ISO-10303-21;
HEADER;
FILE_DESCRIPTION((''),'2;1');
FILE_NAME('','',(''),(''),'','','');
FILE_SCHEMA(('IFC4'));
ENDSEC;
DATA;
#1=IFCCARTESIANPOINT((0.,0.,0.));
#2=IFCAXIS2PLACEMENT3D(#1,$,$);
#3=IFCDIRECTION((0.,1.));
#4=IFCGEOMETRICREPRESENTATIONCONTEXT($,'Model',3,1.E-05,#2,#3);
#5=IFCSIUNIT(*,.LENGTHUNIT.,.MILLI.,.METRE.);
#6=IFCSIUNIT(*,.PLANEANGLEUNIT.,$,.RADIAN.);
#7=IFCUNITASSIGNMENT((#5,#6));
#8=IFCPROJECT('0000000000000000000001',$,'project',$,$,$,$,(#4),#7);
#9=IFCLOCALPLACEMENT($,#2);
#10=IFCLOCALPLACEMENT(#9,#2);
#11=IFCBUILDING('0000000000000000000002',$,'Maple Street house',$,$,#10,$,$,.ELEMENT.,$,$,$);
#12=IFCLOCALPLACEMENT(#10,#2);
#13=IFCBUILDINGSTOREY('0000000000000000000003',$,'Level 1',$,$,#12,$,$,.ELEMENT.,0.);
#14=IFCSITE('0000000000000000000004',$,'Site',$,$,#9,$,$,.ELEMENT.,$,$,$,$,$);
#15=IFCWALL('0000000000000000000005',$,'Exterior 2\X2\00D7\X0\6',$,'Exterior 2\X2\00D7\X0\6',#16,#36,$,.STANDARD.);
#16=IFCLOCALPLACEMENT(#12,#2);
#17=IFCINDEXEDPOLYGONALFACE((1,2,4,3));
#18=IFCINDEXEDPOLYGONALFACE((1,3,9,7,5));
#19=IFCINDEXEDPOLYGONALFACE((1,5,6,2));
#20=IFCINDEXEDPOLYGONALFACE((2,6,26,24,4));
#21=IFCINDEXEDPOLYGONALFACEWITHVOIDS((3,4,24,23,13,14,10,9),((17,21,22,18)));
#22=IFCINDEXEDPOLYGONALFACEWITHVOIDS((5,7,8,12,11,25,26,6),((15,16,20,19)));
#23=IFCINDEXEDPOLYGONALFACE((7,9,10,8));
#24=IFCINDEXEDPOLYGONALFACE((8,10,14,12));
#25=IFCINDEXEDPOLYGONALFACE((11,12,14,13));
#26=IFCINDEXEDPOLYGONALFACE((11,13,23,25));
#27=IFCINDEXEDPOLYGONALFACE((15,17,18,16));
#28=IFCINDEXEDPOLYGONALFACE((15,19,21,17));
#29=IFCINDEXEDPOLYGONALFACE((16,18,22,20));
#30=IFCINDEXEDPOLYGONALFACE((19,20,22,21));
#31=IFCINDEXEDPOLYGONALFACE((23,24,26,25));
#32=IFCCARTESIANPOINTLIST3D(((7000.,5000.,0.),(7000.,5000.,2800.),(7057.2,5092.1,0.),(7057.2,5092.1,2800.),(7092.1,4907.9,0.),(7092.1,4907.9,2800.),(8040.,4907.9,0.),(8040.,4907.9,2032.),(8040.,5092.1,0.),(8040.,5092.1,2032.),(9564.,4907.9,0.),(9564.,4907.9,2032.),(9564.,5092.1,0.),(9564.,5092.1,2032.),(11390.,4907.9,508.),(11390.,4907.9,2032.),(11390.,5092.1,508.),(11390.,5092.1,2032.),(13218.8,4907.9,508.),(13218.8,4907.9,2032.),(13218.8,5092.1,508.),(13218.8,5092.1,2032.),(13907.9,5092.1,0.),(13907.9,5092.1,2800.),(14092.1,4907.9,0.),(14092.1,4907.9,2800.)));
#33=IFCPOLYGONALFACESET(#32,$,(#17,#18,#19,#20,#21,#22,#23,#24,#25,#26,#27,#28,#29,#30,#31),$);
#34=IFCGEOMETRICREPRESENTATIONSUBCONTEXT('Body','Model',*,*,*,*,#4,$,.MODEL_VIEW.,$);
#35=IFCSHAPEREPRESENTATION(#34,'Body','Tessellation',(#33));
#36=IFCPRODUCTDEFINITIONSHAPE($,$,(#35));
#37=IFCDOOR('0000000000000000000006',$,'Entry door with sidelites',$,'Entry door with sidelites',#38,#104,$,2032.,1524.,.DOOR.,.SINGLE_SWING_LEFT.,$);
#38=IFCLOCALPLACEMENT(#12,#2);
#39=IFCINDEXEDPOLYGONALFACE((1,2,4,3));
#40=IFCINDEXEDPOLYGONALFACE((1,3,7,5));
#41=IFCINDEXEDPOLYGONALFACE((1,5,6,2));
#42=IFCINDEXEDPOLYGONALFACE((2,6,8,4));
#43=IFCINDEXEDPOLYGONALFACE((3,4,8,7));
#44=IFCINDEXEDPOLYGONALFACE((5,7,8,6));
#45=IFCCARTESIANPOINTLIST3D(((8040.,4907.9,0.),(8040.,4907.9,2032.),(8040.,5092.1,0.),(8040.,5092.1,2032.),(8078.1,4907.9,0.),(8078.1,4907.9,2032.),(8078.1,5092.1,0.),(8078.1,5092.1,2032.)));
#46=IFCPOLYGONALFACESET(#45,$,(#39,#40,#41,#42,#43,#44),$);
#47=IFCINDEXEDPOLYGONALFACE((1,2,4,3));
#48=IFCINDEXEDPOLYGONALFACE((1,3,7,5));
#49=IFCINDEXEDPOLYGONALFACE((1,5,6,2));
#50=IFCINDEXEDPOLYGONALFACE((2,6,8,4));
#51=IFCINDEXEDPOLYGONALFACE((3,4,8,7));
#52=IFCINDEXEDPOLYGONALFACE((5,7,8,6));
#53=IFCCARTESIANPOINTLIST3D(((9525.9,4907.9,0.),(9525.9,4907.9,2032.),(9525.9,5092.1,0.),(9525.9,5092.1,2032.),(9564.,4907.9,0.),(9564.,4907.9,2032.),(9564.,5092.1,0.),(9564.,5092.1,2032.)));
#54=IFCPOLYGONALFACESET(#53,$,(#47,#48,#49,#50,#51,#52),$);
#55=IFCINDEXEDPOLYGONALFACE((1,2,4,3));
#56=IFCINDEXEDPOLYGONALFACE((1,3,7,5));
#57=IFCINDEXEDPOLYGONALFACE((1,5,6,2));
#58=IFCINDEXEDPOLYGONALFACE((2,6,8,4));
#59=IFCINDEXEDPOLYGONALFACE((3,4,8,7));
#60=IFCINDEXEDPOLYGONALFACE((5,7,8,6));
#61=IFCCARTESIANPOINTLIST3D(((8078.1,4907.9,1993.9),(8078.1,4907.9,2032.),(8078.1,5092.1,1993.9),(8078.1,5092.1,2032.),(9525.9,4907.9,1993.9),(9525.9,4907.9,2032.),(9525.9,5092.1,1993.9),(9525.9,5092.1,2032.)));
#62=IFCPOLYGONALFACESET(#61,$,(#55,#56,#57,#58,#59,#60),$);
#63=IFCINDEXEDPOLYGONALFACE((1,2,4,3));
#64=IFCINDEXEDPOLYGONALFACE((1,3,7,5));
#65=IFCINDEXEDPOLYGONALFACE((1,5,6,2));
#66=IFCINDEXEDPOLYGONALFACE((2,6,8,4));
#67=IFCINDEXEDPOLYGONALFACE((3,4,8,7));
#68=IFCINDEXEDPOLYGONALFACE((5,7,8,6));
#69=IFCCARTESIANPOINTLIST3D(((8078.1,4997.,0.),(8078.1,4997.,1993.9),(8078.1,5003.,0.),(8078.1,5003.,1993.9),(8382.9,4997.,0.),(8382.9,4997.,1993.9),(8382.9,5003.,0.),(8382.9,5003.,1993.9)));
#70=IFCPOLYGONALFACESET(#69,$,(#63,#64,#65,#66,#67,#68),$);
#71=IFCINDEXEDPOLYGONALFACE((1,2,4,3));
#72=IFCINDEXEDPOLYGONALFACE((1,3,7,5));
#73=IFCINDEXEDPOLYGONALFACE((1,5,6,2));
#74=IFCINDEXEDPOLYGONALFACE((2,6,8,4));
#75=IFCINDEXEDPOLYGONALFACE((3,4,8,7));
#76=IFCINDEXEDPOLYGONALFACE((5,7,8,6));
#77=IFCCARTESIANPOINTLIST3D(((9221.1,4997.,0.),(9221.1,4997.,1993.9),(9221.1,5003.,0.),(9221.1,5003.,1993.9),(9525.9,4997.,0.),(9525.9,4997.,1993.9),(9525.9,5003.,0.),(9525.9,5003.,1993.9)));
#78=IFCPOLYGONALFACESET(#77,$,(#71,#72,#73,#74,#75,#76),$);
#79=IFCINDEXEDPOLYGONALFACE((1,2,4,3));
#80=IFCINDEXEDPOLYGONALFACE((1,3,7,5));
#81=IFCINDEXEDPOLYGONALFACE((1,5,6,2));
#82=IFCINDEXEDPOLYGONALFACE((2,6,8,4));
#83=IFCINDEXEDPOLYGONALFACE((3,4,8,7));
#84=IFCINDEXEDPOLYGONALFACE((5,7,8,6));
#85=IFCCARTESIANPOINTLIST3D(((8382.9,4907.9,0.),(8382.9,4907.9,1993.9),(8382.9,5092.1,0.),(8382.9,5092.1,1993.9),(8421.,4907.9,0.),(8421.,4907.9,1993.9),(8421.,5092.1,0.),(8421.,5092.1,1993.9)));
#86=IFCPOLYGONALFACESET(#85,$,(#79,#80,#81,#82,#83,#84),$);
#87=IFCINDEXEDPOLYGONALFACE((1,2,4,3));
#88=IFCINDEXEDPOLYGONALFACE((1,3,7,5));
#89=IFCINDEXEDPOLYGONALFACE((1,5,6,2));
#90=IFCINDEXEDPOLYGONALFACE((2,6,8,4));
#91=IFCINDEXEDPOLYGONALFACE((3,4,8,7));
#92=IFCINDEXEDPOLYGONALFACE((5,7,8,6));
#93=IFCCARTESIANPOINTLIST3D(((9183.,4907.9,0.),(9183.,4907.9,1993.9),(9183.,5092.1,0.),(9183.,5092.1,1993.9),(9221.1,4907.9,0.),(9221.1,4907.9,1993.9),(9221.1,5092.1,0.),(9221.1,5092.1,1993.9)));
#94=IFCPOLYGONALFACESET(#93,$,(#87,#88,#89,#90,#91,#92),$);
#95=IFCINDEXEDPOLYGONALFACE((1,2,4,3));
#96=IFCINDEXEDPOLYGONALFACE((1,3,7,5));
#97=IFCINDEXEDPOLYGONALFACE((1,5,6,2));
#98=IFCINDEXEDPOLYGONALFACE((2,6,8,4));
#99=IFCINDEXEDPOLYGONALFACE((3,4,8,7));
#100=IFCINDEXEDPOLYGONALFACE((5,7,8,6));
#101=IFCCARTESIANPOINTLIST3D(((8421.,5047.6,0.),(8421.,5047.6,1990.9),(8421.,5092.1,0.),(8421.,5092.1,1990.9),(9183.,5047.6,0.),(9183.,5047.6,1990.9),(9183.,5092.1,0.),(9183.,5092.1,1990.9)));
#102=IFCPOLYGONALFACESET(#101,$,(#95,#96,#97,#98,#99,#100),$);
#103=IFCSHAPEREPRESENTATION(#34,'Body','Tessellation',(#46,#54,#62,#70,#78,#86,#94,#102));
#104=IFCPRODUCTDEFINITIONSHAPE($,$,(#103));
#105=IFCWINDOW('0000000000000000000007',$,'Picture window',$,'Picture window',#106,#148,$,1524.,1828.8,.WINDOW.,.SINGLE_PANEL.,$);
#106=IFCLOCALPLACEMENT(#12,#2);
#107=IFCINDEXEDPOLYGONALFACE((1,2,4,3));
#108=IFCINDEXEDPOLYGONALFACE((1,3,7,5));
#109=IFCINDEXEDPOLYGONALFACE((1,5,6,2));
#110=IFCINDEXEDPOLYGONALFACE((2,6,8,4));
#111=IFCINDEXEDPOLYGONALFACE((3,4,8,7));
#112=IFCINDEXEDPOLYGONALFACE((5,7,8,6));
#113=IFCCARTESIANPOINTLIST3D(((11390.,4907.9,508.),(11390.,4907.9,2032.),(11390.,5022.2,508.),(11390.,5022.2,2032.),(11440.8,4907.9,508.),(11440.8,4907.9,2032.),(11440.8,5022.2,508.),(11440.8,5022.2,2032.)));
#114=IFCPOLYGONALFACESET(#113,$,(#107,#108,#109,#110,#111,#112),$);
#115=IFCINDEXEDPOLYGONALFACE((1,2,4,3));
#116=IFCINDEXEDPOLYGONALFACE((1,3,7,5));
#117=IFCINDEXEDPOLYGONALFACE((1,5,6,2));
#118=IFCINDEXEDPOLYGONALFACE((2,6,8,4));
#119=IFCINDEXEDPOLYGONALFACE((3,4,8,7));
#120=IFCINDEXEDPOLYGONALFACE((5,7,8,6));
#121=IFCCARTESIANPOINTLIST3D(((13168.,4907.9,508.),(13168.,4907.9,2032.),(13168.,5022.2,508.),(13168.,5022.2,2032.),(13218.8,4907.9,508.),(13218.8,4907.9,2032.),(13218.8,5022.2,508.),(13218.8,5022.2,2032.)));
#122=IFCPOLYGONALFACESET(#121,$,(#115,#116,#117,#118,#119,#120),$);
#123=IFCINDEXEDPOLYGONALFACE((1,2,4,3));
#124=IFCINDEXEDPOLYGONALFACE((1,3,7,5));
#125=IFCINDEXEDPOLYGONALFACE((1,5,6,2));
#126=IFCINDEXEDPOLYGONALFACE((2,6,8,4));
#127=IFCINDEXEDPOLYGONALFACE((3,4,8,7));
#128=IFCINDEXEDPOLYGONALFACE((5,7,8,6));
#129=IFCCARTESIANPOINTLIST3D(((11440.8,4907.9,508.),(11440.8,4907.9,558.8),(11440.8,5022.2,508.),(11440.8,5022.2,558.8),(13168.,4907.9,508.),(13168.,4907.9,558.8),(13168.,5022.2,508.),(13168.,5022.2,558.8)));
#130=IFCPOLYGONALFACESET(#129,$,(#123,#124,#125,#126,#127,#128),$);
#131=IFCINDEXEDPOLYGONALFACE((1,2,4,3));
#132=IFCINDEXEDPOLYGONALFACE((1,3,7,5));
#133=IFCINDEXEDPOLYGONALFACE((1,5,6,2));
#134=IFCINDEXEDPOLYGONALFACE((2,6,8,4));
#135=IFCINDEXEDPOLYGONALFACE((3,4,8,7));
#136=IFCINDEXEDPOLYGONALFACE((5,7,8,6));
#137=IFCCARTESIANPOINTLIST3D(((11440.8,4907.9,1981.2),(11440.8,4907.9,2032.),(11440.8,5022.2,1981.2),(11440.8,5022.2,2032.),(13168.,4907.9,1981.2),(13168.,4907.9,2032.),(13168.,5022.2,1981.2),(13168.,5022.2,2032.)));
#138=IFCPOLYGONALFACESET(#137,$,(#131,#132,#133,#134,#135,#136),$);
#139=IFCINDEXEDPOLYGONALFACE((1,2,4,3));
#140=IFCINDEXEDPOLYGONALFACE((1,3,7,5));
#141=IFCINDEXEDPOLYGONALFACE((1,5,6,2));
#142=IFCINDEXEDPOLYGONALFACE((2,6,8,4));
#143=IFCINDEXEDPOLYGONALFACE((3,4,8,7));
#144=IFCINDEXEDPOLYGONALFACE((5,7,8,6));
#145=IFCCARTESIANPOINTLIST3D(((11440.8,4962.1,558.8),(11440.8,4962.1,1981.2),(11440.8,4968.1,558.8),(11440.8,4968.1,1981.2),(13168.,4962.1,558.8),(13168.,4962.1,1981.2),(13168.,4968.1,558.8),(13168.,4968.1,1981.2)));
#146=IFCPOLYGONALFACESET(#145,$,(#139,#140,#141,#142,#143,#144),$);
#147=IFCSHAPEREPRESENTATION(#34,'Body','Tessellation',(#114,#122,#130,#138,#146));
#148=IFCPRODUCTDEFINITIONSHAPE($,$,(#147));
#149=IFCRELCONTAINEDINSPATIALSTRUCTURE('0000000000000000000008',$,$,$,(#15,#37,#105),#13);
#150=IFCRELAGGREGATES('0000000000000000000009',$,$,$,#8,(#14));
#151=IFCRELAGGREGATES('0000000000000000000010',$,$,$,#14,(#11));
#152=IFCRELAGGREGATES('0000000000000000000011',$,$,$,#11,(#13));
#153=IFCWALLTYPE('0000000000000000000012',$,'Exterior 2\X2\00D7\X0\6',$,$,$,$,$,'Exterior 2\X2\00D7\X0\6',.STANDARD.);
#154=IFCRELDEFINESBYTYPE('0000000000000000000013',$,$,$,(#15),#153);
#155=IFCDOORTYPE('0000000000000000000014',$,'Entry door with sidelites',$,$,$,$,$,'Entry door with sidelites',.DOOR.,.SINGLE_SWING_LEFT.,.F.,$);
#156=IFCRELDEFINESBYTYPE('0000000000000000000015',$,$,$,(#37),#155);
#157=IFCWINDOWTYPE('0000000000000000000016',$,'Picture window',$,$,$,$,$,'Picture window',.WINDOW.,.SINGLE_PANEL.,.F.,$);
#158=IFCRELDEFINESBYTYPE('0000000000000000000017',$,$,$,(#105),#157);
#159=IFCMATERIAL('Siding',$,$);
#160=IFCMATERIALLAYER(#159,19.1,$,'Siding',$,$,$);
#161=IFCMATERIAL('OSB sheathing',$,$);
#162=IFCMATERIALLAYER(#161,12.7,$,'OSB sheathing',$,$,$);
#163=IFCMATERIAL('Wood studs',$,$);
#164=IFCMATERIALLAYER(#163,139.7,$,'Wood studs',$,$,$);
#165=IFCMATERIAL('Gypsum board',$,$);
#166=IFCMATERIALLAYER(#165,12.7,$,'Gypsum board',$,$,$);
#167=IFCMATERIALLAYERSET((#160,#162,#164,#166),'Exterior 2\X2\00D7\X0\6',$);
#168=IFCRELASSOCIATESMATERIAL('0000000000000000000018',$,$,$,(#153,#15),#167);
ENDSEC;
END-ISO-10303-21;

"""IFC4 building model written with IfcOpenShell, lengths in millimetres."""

from ifc_helpers import new_model, si_unit, direction, frame, origin, origin_with_axes, place, context, subcontext, project, spatial, polyline, outline, extrude, material, layer, layer_set, layer_usage, type_object, element, fill, save


model = new_model("IFC4")

# Units and contexts
model_context = context("Model", 3, precision=1e-05, world=origin(), true_north=direction((0.0, 1.0)))
body_context = subcontext(model_context, "Body", "Model", "MODEL_VIEW")
ifc_project = project(units=[si_unit("LENGTHUNIT", "METRE", prefix="MILLI"), si_unit("PLANEANGLEUNIT", "RADIAN")], contexts=[model_context])

# Site, building, storey
site_placement = place(None, origin())
site = spatial("IfcSite", under=ifc_project, at=site_placement, Name="Site", CompositionType="ELEMENT")
building_placement = place(site_placement, origin())
building = spatial("IfcBuilding", under=site, at=building_placement, Name="Maple Street house", CompositionType="ELEMENT")
storey_placement = place(building_placement, origin())
storey = spatial("IfcBuildingStorey", under=building, at=storey_placement, Name="Level 1", CompositionType="ELEMENT", Elevation=0.0)

# Wall, openings, door, window
ifc_material_1 = material(Name="Siding")
ifc_layer_1 = layer(ifc_material_1, 19.1, Name="Siding")
ifc_material_2 = material(Name="OSB sheathing")
ifc_layer_2 = layer(ifc_material_2, 12.7, Name="OSB sheathing")
ifc_material_3 = material(Name="Wood studs")
ifc_layer_3 = layer(ifc_material_3, 139.7, Name="Wood studs")
ifc_material_4 = material(Name="Gypsum board")
ifc_layer_4 = layer(ifc_material_4, 12.7, Name="Gypsum board")
ifc_layer_set_1 = layer_set([ifc_layer_1, ifc_layer_2, ifc_layer_3, ifc_layer_4], Name="Exterior 2×6")
ifc_layer_usage_1 = layer_usage(ifc_layer_set_1, "AXIS2", "POSITIVE", -92.1)
wall_type_1 = type_object("IfcWallType", Name="Exterior 2×6", ElementType="Exterior 2×6", PredefinedType="STANDARD", material=ifc_layer_set_1)
wall_1_placement = place(storey_placement, frame((7000.0, 5000.0, 0.0), z_axis=(0.0, 0.0, 1.0), x_axis=(1.0, 0.0, 0.0)))
wall_1 = element("IfcWall", 1, at=wall_1_placement, inside=storey, type_object=wall_type_1, material=ifc_layer_usage_1, Name="Exterior 2×6", ObjectType="Exterior 2×6", PredefinedType="STANDARD", context=body_context, shape_type="SweptSolid", body=[
    extrude(outline(polyline([(92.1, -92.1), (7092.1, -92.1), (6907.9, 92.1), (57.1, 92.1), (0.0, 0.0), (92.1, -92.1)])), origin(), (0.0, 0.0, 1.0), 2800.0),
])
opening_1_placement = place(wall_1_placement, frame((1040.0, 0.0, 0.0), z_axis=(0.0, 0.0, 1.0), x_axis=(1.0, 0.0, 0.0)))
opening_1 = element("IfcOpeningElement", 2, at=opening_1_placement, cuts=wall_1, PredefinedType="OPENING", context=body_context, shape_type="SweptSolid", body=[
    extrude(outline(polyline([(0.0, -102.1), (1524.0, -102.1), (1524.0, 102.1), (0.0, 102.1), (0.0, -102.1)])), origin(), (0.0, 0.0, 1.0), 2032.0),
])
opening_2_placement = place(wall_1_placement, frame((4390.0, 0.0, 508.0), z_axis=(0.0, 0.0, 1.0), x_axis=(1.0, 0.0, 0.0)))
opening_2 = element("IfcOpeningElement", 3, at=opening_2_placement, cuts=wall_1, PredefinedType="OPENING", context=body_context, shape_type="SweptSolid", body=[
    extrude(outline(polyline([(0.0, -102.1), (1828.8, -102.1), (1828.8, 102.1), (0.0, 102.1), (0.0, -102.1)])), origin(), (0.0, 0.0, 1.0), 1524.0),
])
door_type_1 = type_object("IfcDoorType", Name="Entry door with sidelites", ElementType="Entry door with sidelites", OperationType="SINGLE_SWING_LEFT", ParameterTakesPrecedence=False, PredefinedType="DOOR")
door_1_placement = place(opening_1_placement, origin_with_axes())
door_1 = element("IfcDoor", 4, at=door_1_placement, inside=storey, type_object=door_type_1, Name="Entry door with sidelites", ObjectType="Entry door with sidelites", OperationType="SINGLE_SWING_LEFT", OverallHeight=2032.0, OverallWidth=1524.0, PredefinedType="DOOR", context=body_context, shape_type="SweptSolid", body=[
    extrude(outline(polyline([(0.0, -92.1), (38.1, -92.1), (38.1, 92.1), (0.0, 92.1), (0.0, -92.1)])), origin(), (0.0, 0.0, 1.0), 2032.0),
    extrude(outline(polyline([(1485.9, -92.1), (1524.0, -92.1), (1524.0, 92.1), (1485.9, 92.1), (1485.9, -92.1)])), origin(), (0.0, 0.0, 1.0), 2032.0),
    extrude(outline(polyline([(38.1, -92.1), (1485.9, -92.1), (1485.9, 92.1), (38.1, 92.1), (38.1, -92.1)])), frame((0.0, 0.0, 1993.9)), (0.0, 0.0, 1.0), 38.1),
    extrude(outline(polyline([(38.1, -3.0), (342.9, -3.0), (342.9, 3.0), (38.1, 3.0), (38.1, -3.0)])), origin(), (0.0, 0.0, 1.0), 1993.9),
    extrude(outline(polyline([(1181.1, -3.0), (1485.9, -3.0), (1485.9, 3.0), (1181.1, 3.0), (1181.1, -3.0)])), origin(), (0.0, 0.0, 1.0), 1993.9),
    extrude(outline(polyline([(342.9, -92.1), (381.0, -92.1), (381.0, 92.1), (342.9, 92.1), (342.9, -92.1)])), origin(), (0.0, 0.0, 1.0), 1993.9),
    extrude(outline(polyline([(1143.0, -92.1), (1181.1, -92.1), (1181.1, 92.1), (1143.0, 92.1), (1143.0, -92.1)])), origin(), (0.0, 0.0, 1.0), 1993.9),
    extrude(outline(polyline([(381.0, 47.6), (1143.0, 47.6), (1143.0, 92.1), (381.0, 92.1), (381.0, 47.6)])), origin(), (0.0, 0.0, 1.0), 1990.9),
])
fill(opening_1, door_1)
window_type_1 = type_object("IfcWindowType", Name="Picture window", ElementType="Picture window", ParameterTakesPrecedence=False, PartitioningType="SINGLE_PANEL", PredefinedType="WINDOW")
window_1_placement = place(opening_2_placement, origin_with_axes())
window_1 = element("IfcWindow", 5, at=window_1_placement, inside=storey, type_object=window_type_1, Name="Picture window", ObjectType="Picture window", OverallHeight=1524.0, OverallWidth=1828.8, PartitioningType="SINGLE_PANEL", PredefinedType="WINDOW", context=body_context, shape_type="SweptSolid", body=[
    extrude(outline(polyline([(0.0, -92.1), (50.8, -92.1), (50.8, 22.2), (0.0, 22.2), (0.0, -92.1)])), origin(), (0.0, 0.0, 1.0), 1524.0),
    extrude(outline(polyline([(1778.0, -92.1), (1828.8, -92.1), (1828.8, 22.2), (1778.0, 22.2), (1778.0, -92.1)])), origin(), (0.0, 0.0, 1.0), 1524.0),
    extrude(outline(polyline([(50.8, -92.1), (1778.0, -92.1), (1778.0, 22.2), (50.8, 22.2), (50.8, -92.1)])), origin(), (0.0, 0.0, 1.0), 50.8),
    extrude(outline(polyline([(50.8, -92.1), (1778.0, -92.1), (1778.0, 22.2), (50.8, 22.2), (50.8, -92.1)])), frame((0.0, 0.0, 1473.2)), (0.0, 0.0, 1.0), 50.8),
    extrude(outline(polyline([(50.8, -37.9), (1778.0, -37.9), (1778.0, -31.9), (50.8, -31.9), (50.8, -37.9)])), frame((0.0, 0.0, 50.8)), (0.0, 0.0, 1.0), 1422.4),
])
fill(opening_2, window_1)

save(model, "model.ifc")
